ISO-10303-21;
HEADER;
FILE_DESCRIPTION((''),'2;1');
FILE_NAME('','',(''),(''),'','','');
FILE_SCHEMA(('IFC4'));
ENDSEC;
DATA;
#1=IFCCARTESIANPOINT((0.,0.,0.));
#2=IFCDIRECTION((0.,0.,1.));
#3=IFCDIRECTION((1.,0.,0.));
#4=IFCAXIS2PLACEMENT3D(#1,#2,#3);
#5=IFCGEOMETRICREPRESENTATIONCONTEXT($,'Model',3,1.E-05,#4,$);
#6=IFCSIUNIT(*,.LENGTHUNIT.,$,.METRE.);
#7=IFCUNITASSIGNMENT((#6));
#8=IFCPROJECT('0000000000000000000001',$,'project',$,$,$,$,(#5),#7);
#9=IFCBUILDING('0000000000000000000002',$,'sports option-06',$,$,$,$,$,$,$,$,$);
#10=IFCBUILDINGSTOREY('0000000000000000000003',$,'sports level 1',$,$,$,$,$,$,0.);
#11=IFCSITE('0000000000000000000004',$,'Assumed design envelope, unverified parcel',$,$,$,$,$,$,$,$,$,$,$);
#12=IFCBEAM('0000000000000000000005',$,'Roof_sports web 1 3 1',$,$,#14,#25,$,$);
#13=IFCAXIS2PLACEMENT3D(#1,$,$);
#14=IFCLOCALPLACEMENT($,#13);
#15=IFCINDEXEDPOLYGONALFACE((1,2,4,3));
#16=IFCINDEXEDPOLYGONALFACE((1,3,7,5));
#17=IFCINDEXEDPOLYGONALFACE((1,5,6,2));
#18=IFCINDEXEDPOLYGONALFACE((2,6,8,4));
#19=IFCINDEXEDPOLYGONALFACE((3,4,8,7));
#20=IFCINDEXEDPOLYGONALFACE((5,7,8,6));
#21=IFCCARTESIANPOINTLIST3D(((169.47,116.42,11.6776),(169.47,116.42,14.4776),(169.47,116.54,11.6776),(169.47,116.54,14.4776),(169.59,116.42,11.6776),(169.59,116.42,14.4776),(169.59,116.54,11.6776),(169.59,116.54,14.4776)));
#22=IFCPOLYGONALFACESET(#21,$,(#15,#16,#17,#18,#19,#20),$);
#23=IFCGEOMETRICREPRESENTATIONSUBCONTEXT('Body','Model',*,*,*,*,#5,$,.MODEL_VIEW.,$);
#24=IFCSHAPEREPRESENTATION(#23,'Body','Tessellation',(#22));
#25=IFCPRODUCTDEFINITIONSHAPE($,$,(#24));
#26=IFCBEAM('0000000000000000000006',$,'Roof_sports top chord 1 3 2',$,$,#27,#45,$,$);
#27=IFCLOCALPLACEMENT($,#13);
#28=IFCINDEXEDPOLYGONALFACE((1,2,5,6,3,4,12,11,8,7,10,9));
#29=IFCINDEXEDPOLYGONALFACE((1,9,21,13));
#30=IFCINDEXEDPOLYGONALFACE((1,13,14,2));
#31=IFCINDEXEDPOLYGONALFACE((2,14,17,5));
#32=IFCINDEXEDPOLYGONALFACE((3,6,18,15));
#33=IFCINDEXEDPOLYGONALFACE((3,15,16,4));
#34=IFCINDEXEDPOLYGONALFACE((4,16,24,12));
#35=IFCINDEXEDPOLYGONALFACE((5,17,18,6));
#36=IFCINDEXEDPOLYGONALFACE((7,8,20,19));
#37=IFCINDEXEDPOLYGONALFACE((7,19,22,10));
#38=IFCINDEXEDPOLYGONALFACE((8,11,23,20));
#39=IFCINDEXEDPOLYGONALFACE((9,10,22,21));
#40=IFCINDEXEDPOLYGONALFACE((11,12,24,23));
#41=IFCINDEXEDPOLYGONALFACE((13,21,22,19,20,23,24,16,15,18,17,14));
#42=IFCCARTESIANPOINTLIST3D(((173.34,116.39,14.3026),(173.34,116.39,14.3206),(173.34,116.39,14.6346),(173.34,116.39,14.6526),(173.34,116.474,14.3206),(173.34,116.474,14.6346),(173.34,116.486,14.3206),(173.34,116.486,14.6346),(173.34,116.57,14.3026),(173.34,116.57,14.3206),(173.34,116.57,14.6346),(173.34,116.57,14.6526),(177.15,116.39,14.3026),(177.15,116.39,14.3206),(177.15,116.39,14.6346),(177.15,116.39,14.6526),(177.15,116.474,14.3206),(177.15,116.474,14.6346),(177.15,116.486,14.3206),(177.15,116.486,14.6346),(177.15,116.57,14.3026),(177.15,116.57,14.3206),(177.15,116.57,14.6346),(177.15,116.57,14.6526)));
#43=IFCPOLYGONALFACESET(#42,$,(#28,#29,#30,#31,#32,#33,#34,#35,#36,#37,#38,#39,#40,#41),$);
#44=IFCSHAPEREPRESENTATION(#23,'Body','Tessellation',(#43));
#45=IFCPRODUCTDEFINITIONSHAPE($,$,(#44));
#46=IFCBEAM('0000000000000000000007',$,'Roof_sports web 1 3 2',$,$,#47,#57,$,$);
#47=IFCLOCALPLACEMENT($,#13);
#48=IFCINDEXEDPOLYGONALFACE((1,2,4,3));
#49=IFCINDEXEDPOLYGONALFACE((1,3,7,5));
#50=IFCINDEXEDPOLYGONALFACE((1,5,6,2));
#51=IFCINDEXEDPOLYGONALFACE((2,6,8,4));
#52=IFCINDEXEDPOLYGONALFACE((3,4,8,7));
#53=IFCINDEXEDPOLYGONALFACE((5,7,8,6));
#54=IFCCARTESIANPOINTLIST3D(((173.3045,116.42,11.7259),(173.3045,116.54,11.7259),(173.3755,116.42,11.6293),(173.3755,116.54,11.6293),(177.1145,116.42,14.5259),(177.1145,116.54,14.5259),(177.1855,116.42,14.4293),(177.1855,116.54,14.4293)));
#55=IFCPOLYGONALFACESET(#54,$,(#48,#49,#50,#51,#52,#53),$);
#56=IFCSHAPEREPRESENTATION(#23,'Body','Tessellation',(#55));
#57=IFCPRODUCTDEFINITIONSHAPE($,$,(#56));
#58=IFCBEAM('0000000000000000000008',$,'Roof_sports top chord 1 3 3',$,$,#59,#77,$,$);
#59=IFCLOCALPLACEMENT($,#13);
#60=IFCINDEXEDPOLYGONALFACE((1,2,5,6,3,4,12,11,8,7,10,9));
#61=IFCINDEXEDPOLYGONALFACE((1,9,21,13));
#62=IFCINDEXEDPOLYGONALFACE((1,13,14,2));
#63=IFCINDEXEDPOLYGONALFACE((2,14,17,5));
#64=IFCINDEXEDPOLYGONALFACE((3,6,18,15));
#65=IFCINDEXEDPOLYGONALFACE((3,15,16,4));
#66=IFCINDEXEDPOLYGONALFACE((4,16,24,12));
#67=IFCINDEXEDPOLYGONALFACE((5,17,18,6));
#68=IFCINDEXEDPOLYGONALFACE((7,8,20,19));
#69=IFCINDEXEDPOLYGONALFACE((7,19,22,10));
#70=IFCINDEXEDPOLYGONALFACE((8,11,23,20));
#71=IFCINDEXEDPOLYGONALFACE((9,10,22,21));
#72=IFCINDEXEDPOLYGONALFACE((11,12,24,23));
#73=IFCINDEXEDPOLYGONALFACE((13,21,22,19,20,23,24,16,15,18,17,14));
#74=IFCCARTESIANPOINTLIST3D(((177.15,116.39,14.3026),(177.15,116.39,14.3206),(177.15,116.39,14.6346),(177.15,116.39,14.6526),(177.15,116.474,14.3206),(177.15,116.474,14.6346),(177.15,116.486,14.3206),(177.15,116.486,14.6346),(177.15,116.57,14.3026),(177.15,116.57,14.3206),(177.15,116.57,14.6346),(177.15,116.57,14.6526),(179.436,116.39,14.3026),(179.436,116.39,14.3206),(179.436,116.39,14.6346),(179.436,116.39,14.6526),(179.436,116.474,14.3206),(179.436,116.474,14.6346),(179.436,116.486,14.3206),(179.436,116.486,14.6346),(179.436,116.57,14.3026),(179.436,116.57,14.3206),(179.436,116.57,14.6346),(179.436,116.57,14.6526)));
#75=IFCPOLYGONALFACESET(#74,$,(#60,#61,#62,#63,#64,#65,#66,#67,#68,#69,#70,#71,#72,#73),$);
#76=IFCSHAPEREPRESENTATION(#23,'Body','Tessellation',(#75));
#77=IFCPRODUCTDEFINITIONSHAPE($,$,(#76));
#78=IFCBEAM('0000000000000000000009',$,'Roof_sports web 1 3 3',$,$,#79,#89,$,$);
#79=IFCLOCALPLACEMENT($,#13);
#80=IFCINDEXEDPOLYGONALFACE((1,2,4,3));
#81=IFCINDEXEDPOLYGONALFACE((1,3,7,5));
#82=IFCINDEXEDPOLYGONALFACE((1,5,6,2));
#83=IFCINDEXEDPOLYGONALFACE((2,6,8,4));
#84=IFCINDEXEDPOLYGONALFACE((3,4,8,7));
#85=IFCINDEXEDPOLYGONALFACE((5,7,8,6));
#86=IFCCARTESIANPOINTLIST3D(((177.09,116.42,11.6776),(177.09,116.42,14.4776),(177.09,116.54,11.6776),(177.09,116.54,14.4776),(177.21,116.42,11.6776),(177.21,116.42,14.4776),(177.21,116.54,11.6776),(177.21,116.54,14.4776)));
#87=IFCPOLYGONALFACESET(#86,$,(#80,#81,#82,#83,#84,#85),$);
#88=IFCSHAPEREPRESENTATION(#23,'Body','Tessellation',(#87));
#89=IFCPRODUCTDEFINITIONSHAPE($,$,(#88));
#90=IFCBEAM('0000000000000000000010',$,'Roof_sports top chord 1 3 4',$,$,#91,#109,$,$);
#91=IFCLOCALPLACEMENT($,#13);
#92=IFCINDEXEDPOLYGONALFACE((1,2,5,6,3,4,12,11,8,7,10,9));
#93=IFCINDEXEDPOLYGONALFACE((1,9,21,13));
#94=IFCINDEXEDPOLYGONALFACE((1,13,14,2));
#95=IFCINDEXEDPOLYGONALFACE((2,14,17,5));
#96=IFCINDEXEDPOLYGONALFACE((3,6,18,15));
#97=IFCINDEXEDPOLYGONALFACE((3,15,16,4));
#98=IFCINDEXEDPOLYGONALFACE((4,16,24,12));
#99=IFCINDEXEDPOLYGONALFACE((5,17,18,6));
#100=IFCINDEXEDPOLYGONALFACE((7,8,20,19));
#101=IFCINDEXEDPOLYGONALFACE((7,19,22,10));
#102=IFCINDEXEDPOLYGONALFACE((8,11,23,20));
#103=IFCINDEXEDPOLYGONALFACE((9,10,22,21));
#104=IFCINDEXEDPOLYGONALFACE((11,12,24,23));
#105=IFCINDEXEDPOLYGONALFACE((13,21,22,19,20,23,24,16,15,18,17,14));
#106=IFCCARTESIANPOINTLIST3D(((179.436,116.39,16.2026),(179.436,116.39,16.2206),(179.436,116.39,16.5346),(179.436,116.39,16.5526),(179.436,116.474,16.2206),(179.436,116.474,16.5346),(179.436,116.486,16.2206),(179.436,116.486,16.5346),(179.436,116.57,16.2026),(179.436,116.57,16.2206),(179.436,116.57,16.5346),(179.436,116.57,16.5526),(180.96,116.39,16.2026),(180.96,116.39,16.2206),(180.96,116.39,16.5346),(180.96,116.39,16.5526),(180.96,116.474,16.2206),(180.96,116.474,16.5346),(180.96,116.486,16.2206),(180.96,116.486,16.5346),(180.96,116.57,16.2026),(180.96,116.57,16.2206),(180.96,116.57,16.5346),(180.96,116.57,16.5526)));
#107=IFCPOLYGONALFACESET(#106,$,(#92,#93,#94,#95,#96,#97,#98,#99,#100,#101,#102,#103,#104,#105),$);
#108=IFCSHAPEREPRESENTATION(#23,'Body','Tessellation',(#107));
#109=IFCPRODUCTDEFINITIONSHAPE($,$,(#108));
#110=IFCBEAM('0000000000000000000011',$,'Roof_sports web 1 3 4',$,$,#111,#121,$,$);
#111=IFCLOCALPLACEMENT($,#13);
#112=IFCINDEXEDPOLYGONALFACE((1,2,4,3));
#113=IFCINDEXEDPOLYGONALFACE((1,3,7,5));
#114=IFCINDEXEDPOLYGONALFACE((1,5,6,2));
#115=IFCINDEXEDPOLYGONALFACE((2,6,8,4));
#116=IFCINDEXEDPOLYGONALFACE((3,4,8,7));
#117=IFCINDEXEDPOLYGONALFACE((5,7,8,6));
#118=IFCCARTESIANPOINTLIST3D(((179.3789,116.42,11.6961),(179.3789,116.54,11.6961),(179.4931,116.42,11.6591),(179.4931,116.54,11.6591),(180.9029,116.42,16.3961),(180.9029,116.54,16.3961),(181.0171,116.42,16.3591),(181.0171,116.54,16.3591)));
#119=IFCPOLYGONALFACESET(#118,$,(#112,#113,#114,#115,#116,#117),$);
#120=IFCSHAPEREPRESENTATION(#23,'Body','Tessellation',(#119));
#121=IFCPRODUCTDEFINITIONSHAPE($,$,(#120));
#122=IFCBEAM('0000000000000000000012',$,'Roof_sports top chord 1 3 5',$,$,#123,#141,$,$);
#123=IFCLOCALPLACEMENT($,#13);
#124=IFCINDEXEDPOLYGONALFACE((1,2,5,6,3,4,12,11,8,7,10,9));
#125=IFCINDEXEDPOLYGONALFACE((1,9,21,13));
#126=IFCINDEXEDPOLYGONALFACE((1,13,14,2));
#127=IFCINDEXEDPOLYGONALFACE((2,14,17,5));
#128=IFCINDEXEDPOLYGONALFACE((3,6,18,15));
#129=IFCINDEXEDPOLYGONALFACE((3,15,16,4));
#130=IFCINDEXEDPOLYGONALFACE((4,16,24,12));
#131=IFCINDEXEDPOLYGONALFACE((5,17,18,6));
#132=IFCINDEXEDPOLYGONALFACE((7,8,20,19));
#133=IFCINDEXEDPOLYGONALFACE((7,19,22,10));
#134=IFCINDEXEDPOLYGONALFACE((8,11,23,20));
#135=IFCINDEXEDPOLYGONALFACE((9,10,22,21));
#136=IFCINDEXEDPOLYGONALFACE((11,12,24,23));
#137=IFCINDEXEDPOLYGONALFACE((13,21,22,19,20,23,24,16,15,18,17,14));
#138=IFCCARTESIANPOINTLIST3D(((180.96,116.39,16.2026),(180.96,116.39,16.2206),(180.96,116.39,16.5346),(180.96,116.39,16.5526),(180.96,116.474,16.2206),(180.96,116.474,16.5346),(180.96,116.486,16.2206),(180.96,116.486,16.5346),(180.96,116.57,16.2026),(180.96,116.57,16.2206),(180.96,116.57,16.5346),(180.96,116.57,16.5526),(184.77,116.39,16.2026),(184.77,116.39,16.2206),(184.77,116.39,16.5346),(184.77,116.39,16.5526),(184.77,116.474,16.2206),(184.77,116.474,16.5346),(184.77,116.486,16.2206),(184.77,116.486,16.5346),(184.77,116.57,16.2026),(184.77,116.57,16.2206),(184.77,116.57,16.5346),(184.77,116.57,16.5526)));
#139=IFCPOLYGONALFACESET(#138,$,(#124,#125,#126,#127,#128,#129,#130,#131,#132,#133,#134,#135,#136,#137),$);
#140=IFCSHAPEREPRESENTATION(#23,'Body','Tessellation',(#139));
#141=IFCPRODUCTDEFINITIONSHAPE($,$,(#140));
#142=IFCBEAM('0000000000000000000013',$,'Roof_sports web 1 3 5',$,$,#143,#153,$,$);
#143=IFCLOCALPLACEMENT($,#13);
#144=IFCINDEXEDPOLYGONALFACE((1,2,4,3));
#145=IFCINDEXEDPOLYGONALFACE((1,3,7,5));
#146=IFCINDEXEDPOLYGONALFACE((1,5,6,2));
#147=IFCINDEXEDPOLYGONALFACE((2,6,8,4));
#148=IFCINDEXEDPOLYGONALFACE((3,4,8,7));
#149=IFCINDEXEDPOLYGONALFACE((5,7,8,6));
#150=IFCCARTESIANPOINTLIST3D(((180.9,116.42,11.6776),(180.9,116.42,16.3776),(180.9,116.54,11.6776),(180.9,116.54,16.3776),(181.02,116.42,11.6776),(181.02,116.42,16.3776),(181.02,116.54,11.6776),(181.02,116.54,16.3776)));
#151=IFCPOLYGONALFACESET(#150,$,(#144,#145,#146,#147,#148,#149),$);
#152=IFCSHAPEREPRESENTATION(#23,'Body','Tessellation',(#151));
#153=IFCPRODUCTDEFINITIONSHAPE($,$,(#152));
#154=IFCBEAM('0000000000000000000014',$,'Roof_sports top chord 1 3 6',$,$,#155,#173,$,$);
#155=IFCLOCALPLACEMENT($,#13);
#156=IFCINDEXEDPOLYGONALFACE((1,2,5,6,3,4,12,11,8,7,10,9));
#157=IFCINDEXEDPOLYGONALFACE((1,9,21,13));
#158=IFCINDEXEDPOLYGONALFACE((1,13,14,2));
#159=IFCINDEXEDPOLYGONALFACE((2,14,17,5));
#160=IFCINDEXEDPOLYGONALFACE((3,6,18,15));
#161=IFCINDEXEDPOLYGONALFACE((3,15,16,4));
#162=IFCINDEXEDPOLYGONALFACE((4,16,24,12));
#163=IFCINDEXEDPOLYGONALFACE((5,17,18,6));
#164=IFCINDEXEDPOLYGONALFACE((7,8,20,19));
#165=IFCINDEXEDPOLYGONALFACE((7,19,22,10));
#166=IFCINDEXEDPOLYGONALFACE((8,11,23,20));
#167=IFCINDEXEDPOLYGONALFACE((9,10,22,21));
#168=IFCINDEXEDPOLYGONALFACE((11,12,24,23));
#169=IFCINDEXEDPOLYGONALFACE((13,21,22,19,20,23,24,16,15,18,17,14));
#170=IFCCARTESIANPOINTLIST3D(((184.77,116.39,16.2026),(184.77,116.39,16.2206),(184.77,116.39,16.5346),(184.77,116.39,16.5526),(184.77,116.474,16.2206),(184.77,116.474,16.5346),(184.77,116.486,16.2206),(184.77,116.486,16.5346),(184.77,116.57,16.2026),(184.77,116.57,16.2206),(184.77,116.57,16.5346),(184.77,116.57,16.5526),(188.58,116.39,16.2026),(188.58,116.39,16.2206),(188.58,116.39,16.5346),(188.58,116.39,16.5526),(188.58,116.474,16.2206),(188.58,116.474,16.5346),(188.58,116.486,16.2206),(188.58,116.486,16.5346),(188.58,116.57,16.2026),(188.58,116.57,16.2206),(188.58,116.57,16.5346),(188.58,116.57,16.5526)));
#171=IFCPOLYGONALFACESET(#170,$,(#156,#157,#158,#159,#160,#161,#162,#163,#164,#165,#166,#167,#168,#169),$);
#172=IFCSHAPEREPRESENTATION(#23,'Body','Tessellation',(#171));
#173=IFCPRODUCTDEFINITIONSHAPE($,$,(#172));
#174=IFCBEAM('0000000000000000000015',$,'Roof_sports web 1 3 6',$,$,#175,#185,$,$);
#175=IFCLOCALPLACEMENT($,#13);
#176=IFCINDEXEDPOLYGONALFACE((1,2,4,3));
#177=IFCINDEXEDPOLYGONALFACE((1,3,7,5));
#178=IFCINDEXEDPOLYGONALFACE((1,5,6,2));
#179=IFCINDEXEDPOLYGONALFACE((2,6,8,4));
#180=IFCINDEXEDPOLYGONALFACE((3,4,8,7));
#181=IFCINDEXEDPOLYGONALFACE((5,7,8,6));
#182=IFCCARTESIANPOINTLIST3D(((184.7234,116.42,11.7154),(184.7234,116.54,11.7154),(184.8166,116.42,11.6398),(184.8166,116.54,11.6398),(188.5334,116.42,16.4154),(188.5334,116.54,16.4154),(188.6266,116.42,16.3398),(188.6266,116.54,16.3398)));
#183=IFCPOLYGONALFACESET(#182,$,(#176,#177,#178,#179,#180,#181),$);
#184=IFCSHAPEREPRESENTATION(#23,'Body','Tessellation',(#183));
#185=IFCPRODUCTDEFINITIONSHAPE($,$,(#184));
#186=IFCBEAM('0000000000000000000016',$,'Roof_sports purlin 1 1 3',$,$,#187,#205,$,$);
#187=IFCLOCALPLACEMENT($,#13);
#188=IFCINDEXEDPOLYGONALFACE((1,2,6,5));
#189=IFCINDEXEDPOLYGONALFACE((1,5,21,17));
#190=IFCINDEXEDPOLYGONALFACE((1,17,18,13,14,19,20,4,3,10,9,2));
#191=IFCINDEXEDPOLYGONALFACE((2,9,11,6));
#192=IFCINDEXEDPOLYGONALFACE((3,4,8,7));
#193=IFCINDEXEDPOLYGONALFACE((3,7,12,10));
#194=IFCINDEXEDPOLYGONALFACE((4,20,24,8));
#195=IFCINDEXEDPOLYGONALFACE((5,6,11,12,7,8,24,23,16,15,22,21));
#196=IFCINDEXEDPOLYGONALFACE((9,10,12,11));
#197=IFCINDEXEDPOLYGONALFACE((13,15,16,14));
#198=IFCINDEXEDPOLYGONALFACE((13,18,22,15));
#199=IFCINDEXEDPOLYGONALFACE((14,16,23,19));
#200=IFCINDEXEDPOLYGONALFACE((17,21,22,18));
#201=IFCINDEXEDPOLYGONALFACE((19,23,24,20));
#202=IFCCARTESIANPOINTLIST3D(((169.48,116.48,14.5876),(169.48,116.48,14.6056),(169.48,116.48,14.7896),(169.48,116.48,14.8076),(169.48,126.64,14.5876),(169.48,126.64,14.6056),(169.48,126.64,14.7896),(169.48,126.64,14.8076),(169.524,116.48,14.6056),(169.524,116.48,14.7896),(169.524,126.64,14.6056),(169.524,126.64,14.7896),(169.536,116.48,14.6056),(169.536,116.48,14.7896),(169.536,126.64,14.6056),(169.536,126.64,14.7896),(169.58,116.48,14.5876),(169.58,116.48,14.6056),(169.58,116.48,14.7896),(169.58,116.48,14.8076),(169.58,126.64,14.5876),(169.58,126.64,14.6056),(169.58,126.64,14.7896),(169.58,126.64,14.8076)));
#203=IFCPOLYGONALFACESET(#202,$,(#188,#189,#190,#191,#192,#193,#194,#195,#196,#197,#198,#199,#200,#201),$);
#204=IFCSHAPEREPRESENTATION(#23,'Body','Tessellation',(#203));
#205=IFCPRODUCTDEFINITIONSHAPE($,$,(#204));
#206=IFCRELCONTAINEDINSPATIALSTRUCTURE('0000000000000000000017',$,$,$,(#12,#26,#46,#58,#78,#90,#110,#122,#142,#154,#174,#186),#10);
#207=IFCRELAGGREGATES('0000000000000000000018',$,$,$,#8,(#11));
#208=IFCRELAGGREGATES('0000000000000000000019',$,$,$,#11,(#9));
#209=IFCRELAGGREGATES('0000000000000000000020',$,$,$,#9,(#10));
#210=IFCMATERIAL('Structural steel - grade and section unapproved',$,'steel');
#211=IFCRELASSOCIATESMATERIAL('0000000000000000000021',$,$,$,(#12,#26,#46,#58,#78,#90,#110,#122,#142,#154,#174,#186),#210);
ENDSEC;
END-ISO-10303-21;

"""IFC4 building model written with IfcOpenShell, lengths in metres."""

from ifc_helpers import new_model, si_unit, frame, origin_with_axes, place, context, subcontext, project, spatial, rectangle, i_section, extrude, material, element, save


model = new_model("IFC4")

# Units and contexts
model_context = context("Model", 3, precision=1e-05, world=origin_with_axes())
body_context = subcontext(model_context, "Body", "Model", "MODEL_VIEW")
ifc_project = project(units=[si_unit("LENGTHUNIT", "METRE")], contexts=[model_context])

# Site, building, storey
site = spatial("IfcSite", under=ifc_project, Name="Assumed design envelope, unverified parcel")
building = spatial("IfcBuilding", under=site, Name="sports option-06")
storey = spatial("IfcBuildingStorey", under=building, Name="sports level 1", Elevation=0.0)

# Shared definitions
ifc_material = material(Name="Structural steel - grade and section unapproved", Category="steel")

# Beams
beam_1_placement = place(None, frame((169.53, 116.48, 11.6776), z_axis=(0.0, 0.0, 1.0), x_axis=(-1.0, 0.0, 0.0)))
element("IfcBeam", 1, at=beam_1_placement, inside=storey, material=ifc_material, Name="Roof_sports web 1 3 1", context=body_context, shape_type="SweptSolid", body=[
    extrude(rectangle(XDim=0.12, YDim=0.12), origin_with_axes(), (0.0, 0.0, 1.0), 2.8),
])
beam_2_placement = place(None, frame((173.34, 116.48, 14.4776), z_axis=(1.0, 0.0, 0.0), x_axis=(0.0, 1.0, 0.0)))
element("IfcBeam", 2, at=beam_2_placement, inside=storey, material=ifc_material, Name="Roof_sports top chord 1 3 2", context=body_context, shape_type="SweptSolid", body=[
    extrude(i_section(OverallWidth=0.18, OverallDepth=0.35, WebThickness=0.012, FlangeThickness=0.018, FilletRadius=0.0), origin_with_axes(), (0.0, 0.0, 1.0), 3.81),
])
beam_3_placement = place(None, frame((173.34, 116.48, 11.6776), z_axis=(0.805799, 0.0, 0.592189), x_axis=(0.0, 1.0, 0.0)))
element("IfcBeam", 3, at=beam_3_placement, inside=storey, material=ifc_material, Name="Roof_sports web 1 3 2", context=body_context, shape_type="SweptSolid", body=[
    extrude(rectangle(XDim=0.12, YDim=0.12), origin_with_axes(), (0.0, 0.0, 1.0), 4.7282),
])
beam_4_placement = place(None, frame((177.15, 116.48, 14.4776), z_axis=(1.0, 0.0, 0.0), x_axis=(0.0, 1.0, 0.0)))
element("IfcBeam", 4, at=beam_4_placement, inside=storey, material=ifc_material, Name="Roof_sports top chord 1 3 3", context=body_context, shape_type="SweptSolid", body=[
    extrude(i_section(OverallWidth=0.18, OverallDepth=0.35, WebThickness=0.012, FlangeThickness=0.018, FilletRadius=0.0), origin_with_axes(), (0.0, 0.0, 1.0), 2.286),
])
beam_5_placement = place(None, frame((177.15, 116.48, 11.6776), z_axis=(0.0, 0.0, 1.0), x_axis=(-1.0, 0.0, 0.0)))
element("IfcBeam", 5, at=beam_5_placement, inside=storey, material=ifc_material, Name="Roof_sports web 1 3 3", context=body_context, shape_type="SweptSolid", body=[
    extrude(rectangle(XDim=0.12, YDim=0.12), origin_with_axes(), (0.0, 0.0, 1.0), 2.8),
])
beam_6_placement = place(None, frame((179.436, 116.48, 16.3776), z_axis=(1.0, 0.0, 0.0), x_axis=(0.0, 1.0, 0.0)))
element("IfcBeam", 6, at=beam_6_placement, inside=storey, material=ifc_material, Name="Roof_sports top chord 1 3 4", context=body_context, shape_type="SweptSolid", body=[
    extrude(i_section(OverallWidth=0.18, OverallDepth=0.35, WebThickness=0.012, FlangeThickness=0.018, FilletRadius=0.0), origin_with_axes(), (0.0, 0.0, 1.0), 1.524),
])
beam_7_placement = place(None, frame((179.436, 116.48, 11.6776), z_axis=(0.308446, 0.0, 0.951242), x_axis=(0.0, 1.0, 0.0)))
element("IfcBeam", 7, at=beam_7_placement, inside=storey, material=ifc_material, Name="Roof_sports web 1 3 4", context=body_context, shape_type="SweptSolid", body=[
    extrude(rectangle(XDim=0.12, YDim=0.12), origin_with_axes(), (0.0, 0.0, 1.0), 4.9409),
])
beam_8_placement = place(None, frame((180.96, 116.48, 16.3776), z_axis=(1.0, 0.0, 0.0), x_axis=(0.0, 1.0, 0.0)))
element("IfcBeam", 8, at=beam_8_placement, inside=storey, material=ifc_material, Name="Roof_sports top chord 1 3 5", context=body_context, shape_type="SweptSolid", body=[
    extrude(i_section(OverallWidth=0.18, OverallDepth=0.35, WebThickness=0.012, FlangeThickness=0.018, FilletRadius=0.0), origin_with_axes(), (0.0, 0.0, 1.0), 3.81),
])
beam_9_placement = place(None, frame((180.96, 116.48, 11.6776), z_axis=(0.0, 0.0, 1.0), x_axis=(-1.0, 0.0, 0.0)))
element("IfcBeam", 9, at=beam_9_placement, inside=storey, material=ifc_material, Name="Roof_sports web 1 3 5", context=body_context, shape_type="SweptSolid", body=[
    extrude(rectangle(XDim=0.12, YDim=0.12), origin_with_axes(), (0.0, 0.0, 1.0), 4.7),
])
beam_10_placement = place(None, frame((184.77, 116.48, 16.3776), z_axis=(1.0, 0.0, 0.0), x_axis=(0.0, 1.0, 0.0)))
element("IfcBeam", 10, at=beam_10_placement, inside=storey, material=ifc_material, Name="Roof_sports top chord 1 3 6", context=body_context, shape_type="SweptSolid", body=[
    extrude(i_section(OverallWidth=0.18, OverallDepth=0.35, WebThickness=0.012, FlangeThickness=0.018, FilletRadius=0.0), origin_with_axes(), (0.0, 0.0, 1.0), 3.81),
])
beam_11_placement = place(None, frame((184.77, 116.48, 11.6776), z_axis=(0.629721, 0.0, 0.776821), x_axis=(0.0, 1.0, 0.0)))
element("IfcBeam", 11, at=beam_11_placement, inside=storey, material=ifc_material, Name="Roof_sports web 1 3 6", context=body_context, shape_type="SweptSolid", body=[
    extrude(rectangle(XDim=0.12, YDim=0.12), origin_with_axes(), (0.0, 0.0, 1.0), 6.0503),
])
for number, where, z_axis, x_axis, name in (
    (12, (169.53, 116.48, 14.6976), (0.0, 1.0, 0.0), (-1.0, 0.0, 0.0), "Roof_sports purlin 1 1 3"),
):
    element("IfcBeam", number, at=place(None, frame(where, z_axis=z_axis, x_axis=x_axis)), inside=storey, material=ifc_material, Name=name, context=body_context, shape_type="SweptSolid", body=[
        extrude(i_section(OverallWidth=0.1, OverallDepth=0.22, WebThickness=0.012, FlangeThickness=0.018, FilletRadius=0.0), origin_with_axes(), (0.0, 0.0, 1.0), 10.16),
    ])

save(model, "model.ifc")
